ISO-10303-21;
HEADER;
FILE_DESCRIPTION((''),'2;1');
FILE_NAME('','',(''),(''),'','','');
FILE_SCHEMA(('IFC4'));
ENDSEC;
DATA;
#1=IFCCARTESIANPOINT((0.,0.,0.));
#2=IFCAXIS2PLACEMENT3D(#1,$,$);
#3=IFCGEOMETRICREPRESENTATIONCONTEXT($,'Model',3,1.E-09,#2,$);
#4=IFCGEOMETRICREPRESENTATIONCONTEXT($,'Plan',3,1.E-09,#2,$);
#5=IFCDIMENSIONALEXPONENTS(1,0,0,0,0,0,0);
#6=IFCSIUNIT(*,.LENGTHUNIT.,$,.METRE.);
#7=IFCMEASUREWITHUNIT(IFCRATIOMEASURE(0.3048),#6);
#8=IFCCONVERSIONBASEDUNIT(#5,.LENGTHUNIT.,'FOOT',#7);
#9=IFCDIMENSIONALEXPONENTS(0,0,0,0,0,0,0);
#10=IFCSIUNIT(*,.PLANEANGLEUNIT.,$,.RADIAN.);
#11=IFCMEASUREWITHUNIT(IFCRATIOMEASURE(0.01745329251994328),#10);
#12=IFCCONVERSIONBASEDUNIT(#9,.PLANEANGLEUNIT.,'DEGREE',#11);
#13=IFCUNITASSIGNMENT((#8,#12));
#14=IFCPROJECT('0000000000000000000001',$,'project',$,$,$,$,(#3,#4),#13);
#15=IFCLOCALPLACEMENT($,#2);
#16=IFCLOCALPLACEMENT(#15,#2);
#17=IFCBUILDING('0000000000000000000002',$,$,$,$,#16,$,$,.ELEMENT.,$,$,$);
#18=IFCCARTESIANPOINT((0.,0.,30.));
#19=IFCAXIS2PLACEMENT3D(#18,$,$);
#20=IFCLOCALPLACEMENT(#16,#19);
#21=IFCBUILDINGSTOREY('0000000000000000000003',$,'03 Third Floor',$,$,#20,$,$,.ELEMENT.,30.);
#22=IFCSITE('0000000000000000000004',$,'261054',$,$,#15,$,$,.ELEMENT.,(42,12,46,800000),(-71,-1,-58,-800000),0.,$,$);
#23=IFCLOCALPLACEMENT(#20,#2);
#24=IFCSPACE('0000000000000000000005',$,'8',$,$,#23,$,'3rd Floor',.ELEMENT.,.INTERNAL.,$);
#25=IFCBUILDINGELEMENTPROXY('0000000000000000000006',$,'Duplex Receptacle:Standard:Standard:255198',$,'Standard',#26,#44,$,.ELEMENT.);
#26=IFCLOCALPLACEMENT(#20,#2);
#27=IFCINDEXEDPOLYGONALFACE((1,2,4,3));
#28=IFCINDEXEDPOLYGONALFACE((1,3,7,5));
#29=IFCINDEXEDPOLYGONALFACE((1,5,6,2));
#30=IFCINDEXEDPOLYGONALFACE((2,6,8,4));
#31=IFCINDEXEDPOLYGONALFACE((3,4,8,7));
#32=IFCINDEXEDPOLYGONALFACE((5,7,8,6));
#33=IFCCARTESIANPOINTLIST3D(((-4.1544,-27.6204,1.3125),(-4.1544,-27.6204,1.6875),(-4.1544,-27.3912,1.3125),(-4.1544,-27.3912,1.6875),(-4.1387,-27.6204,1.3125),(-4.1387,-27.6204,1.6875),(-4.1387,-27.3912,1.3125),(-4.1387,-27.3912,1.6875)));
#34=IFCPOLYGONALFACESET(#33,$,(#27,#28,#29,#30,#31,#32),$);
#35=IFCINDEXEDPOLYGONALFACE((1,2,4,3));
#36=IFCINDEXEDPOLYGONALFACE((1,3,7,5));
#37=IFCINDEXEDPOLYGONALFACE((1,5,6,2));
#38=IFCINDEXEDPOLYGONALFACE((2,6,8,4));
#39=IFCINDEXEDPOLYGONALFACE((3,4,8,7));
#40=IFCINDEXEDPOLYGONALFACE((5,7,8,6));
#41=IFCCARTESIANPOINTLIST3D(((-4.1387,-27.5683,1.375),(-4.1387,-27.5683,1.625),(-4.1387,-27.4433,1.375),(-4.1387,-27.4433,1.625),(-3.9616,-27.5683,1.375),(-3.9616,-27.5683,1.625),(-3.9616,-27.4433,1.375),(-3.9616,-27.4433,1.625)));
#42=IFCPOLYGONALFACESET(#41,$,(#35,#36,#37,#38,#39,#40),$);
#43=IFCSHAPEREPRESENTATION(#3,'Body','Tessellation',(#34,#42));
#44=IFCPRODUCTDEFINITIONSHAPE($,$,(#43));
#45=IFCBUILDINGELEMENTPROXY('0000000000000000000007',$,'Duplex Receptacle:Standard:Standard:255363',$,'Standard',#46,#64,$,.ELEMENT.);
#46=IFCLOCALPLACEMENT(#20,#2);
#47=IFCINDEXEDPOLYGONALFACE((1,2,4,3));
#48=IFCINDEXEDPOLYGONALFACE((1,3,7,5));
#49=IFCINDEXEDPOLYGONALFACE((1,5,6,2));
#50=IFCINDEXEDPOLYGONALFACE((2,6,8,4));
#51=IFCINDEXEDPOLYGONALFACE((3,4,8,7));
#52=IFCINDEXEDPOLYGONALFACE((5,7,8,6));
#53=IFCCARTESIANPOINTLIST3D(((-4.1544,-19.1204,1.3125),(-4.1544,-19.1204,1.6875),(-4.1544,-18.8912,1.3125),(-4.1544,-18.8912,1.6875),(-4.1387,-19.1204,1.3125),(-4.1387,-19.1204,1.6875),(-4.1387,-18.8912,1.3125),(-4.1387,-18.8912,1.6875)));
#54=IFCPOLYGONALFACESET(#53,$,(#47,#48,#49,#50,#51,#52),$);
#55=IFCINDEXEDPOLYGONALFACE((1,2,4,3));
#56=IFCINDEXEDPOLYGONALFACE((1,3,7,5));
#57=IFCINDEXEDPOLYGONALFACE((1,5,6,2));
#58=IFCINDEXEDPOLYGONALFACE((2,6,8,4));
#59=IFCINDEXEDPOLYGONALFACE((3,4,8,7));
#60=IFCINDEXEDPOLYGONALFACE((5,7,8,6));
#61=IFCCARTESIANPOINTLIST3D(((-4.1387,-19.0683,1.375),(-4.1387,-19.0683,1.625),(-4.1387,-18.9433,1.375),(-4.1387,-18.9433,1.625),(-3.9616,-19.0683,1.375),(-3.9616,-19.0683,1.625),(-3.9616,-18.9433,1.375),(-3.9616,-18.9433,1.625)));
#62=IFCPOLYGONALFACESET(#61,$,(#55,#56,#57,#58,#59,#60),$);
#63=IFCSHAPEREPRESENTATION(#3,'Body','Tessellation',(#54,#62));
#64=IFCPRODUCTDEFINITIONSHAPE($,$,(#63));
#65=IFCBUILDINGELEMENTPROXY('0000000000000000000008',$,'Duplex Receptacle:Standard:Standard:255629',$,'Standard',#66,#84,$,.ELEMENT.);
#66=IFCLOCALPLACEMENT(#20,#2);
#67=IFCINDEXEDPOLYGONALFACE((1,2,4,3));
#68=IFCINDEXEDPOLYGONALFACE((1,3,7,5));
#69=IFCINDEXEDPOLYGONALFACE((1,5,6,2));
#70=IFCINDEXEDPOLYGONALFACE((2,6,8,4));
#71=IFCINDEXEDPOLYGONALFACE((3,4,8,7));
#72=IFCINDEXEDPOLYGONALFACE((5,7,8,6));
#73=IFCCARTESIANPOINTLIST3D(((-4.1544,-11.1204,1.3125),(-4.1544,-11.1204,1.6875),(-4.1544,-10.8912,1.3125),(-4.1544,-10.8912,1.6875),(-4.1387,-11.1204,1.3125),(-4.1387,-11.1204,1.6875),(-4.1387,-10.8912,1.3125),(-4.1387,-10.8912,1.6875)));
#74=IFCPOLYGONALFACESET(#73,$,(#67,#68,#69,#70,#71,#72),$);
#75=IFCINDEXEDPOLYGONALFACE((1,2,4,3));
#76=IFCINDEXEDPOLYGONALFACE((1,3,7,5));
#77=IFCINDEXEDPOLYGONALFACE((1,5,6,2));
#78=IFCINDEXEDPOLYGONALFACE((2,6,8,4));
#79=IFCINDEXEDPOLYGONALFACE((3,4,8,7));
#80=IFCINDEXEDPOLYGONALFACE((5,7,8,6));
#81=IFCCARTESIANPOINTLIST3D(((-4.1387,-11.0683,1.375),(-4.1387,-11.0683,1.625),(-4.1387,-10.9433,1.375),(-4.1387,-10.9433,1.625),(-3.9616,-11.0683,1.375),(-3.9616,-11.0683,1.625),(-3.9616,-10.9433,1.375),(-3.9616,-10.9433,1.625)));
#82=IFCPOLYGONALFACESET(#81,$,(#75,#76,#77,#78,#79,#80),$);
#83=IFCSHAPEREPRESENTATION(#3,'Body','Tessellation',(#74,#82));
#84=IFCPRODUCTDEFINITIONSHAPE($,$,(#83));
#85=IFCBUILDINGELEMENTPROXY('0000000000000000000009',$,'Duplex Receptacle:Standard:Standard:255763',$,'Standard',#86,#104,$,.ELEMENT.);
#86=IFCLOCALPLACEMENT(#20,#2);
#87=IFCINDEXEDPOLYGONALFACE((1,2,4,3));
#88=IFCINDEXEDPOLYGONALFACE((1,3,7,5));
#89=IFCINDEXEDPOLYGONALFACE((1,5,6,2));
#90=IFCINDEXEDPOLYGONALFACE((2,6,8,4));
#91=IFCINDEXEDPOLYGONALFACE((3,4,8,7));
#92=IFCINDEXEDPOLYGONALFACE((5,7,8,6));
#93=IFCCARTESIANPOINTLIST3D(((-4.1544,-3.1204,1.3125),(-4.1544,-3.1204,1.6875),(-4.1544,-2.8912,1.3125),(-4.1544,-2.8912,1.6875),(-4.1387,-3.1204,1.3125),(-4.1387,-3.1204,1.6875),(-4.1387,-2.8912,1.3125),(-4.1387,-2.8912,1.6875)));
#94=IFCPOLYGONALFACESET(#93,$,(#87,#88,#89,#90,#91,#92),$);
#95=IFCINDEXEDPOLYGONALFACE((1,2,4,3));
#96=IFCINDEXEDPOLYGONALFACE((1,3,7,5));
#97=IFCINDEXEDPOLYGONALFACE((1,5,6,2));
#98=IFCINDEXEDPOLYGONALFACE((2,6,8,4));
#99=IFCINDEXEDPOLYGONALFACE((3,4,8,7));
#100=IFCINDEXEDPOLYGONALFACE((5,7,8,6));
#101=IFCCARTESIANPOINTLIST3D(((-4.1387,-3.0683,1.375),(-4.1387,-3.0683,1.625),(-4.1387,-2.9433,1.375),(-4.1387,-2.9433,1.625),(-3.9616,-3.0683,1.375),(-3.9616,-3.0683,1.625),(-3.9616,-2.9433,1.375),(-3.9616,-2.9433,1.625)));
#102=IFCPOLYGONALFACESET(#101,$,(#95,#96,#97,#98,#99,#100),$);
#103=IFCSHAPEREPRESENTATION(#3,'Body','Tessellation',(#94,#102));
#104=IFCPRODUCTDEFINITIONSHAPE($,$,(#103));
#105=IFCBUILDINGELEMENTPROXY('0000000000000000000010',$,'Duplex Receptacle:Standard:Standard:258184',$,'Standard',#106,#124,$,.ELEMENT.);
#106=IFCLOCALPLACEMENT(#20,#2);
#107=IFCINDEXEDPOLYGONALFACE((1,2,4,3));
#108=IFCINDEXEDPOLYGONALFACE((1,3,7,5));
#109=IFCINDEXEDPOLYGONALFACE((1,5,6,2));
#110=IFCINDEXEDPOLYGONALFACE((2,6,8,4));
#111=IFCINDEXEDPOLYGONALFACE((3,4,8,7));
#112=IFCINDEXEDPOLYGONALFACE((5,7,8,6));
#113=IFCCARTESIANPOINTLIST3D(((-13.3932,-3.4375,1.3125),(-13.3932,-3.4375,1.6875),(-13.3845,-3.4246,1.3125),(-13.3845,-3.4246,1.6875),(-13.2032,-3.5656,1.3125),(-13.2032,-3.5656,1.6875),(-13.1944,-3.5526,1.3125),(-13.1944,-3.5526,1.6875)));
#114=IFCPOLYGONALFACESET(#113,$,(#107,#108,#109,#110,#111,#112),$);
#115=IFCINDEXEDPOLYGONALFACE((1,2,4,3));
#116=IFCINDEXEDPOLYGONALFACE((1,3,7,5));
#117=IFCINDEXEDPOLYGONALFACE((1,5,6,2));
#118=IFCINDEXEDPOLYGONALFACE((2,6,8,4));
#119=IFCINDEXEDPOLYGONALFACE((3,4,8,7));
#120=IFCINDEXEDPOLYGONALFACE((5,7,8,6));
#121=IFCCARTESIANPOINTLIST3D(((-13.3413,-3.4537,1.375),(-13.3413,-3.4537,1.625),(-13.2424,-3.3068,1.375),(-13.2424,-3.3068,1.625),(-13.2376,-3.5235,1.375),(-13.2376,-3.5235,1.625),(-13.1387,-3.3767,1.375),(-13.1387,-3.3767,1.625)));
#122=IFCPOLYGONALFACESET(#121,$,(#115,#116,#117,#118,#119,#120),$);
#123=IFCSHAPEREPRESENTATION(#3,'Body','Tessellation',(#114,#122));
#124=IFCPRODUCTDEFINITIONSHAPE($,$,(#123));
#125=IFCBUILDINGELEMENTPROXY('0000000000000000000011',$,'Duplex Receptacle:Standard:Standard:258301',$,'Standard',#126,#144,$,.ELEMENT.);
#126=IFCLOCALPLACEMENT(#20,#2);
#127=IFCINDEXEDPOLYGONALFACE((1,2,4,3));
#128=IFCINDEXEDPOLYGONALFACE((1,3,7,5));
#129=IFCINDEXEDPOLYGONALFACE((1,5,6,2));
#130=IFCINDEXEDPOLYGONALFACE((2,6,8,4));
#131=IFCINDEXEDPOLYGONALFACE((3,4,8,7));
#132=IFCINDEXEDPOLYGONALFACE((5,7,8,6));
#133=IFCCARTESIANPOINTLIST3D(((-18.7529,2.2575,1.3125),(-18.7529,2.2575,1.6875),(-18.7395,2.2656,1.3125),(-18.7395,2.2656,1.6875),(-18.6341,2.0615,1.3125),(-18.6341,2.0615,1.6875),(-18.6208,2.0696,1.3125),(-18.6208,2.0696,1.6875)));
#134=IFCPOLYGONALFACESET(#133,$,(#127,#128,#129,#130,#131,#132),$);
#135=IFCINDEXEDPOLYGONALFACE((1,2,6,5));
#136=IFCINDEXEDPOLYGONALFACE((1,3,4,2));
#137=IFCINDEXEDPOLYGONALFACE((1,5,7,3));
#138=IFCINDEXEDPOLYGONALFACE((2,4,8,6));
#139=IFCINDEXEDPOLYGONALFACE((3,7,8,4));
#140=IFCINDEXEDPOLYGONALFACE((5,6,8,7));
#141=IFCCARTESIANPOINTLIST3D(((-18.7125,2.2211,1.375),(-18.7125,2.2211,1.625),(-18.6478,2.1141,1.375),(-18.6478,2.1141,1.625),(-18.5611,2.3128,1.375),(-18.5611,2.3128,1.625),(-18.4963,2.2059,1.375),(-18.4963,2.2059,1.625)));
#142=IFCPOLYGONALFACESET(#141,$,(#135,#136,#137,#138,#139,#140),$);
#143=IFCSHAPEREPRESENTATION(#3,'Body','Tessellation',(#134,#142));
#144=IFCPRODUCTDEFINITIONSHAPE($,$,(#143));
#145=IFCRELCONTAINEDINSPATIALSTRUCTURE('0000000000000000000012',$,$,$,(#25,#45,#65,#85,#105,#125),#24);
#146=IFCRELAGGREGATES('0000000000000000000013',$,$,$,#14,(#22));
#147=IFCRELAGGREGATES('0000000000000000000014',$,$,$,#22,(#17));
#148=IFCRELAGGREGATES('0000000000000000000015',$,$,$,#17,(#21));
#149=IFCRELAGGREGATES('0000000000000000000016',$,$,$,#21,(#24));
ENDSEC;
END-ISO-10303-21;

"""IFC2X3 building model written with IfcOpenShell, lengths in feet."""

from ifc_helpers import new_model, entity, si_unit, converted_unit, frame, origin, origin_2d_with_axis, place, context, project, spatial, rectangle, extrude, source, transform, mapped, element, save


model = new_model("IFC2X3")

# Units and contexts
model_context = context("Model", 3, precision=1e-09, world=origin())
plan_context = context("Plan", 3, precision=1e-09, world=origin())
ifc_project = project(units=[converted_unit("LENGTHUNIT", "FOOT", entity("IfcRatioMeasure", 0.3048), si_unit("LENGTHUNIT", "METRE"), dimensions=[1, 0, 0, 0, 0, 0, 0]), converted_unit("PLANEANGLEUNIT", "DEGREE", entity("IfcRatioMeasure", 0.01745329251994328), si_unit("PLANEANGLEUNIT", "RADIAN"), dimensions=[0, 0, 0, 0, 0, 0, 0])], contexts=[model_context, plan_context])

# Site, building, storey
site_placement = place(None, origin())
site = spatial("IfcSite", under=ifc_project, at=site_placement, Name="261054", CompositionType="ELEMENT", RefLatitude=(42, 12, 46, 800000), RefLongitude=(-71, -1, -58, -800000), RefElevation=0.0)
building_placement = place(site_placement, origin())
building = spatial("IfcBuilding", under=site, at=building_placement, CompositionType="ELEMENT")
storey_placement = place(building_placement, frame((0.0, 0.0, 30.0)))
storey = spatial("IfcBuildingStorey", under=building, at=storey_placement, Name="03 Third Floor", CompositionType="ELEMENT", Elevation=30.0)

# Shared definitions
space_1_placement = place(storey_placement, origin())
space_1 = spatial("IfcSpace", under=storey, at=space_1_placement, Name="8", LongName="3rd Floor", CompositionType="ELEMENT", InteriorOrExteriorSpace="INTERNAL")

# Building element proxies
shared_shape_1 = source(origin(), model_context, "Body", "SweptSolid", [
    extrude(rectangle(XDim=0.2292, YDim=0.375, at=origin_2d_with_axis()), frame((0.0, 0.0, 0.0), z_axis=(0.0, 0.0, 1.0), x_axis=(-1.0, 0.0, 0.0)), (0.0, 0.0, 1.0), 0.0156),
    extrude(rectangle(XDim=0.125, YDim=0.25, at=origin_2d_with_axis()), frame((0.0, 0.0, -0.1771), z_axis=(0.0, 0.0, 1.0), x_axis=(-1.0, 0.0, 0.0)), (0.0, 0.0, 1.0), 0.1771),
])
for number, where, z_axis, x_axis, name in (
    (1, (-4.1387, -27.5058, 1.5), (-1.0, 0.0, 0.0), (0.0, -1.0, 0.0), "Duplex Receptacle:Standard:Standard:255198"),
    (2, (-4.1387, -19.0058, 1.5), (-1.0, 0.0, 0.0), (0.0, -1.0, 0.0), "Duplex Receptacle:Standard:Standard:255363"),
    (3, (-4.1387, -11.0058, 1.5), (-1.0, 0.0, 0.0), (0.0, -1.0, 0.0), "Duplex Receptacle:Standard:Standard:255629"),
    (4, (-4.1387, -3.0058, 1.5), (-1.0, 0.0, 0.0), (0.0, -1.0, 0.0), "Duplex Receptacle:Standard:Standard:255763"),
    (5, (-13.2895, -3.4886, 1.5), (-0.558698, -0.829371, 0.0), (0.829371, -0.558698, 0.0), "Duplex Receptacle:Standard:Standard:258184"),
    (6, (-18.6802, 2.1676, 1.5), (-0.855254, -0.518209, 0.0), (0.518209, -0.855254, 0.0), "Duplex Receptacle:Standard:Standard:258301"),
):
    element("IfcBuildingElementProxy", number, at=place(space_1_placement, frame(where, z_axis=z_axis, x_axis=x_axis)), inside=space_1, Name=name, ObjectType="Standard", CompositionType="ELEMENT", context=model_context, shape_type="MappedRepresentation", body=[
        mapped(shared_shape_1, transform((0.0, 0.0, 0.0), scale=1.0)),
    ])

save(model, "model.ifc")
